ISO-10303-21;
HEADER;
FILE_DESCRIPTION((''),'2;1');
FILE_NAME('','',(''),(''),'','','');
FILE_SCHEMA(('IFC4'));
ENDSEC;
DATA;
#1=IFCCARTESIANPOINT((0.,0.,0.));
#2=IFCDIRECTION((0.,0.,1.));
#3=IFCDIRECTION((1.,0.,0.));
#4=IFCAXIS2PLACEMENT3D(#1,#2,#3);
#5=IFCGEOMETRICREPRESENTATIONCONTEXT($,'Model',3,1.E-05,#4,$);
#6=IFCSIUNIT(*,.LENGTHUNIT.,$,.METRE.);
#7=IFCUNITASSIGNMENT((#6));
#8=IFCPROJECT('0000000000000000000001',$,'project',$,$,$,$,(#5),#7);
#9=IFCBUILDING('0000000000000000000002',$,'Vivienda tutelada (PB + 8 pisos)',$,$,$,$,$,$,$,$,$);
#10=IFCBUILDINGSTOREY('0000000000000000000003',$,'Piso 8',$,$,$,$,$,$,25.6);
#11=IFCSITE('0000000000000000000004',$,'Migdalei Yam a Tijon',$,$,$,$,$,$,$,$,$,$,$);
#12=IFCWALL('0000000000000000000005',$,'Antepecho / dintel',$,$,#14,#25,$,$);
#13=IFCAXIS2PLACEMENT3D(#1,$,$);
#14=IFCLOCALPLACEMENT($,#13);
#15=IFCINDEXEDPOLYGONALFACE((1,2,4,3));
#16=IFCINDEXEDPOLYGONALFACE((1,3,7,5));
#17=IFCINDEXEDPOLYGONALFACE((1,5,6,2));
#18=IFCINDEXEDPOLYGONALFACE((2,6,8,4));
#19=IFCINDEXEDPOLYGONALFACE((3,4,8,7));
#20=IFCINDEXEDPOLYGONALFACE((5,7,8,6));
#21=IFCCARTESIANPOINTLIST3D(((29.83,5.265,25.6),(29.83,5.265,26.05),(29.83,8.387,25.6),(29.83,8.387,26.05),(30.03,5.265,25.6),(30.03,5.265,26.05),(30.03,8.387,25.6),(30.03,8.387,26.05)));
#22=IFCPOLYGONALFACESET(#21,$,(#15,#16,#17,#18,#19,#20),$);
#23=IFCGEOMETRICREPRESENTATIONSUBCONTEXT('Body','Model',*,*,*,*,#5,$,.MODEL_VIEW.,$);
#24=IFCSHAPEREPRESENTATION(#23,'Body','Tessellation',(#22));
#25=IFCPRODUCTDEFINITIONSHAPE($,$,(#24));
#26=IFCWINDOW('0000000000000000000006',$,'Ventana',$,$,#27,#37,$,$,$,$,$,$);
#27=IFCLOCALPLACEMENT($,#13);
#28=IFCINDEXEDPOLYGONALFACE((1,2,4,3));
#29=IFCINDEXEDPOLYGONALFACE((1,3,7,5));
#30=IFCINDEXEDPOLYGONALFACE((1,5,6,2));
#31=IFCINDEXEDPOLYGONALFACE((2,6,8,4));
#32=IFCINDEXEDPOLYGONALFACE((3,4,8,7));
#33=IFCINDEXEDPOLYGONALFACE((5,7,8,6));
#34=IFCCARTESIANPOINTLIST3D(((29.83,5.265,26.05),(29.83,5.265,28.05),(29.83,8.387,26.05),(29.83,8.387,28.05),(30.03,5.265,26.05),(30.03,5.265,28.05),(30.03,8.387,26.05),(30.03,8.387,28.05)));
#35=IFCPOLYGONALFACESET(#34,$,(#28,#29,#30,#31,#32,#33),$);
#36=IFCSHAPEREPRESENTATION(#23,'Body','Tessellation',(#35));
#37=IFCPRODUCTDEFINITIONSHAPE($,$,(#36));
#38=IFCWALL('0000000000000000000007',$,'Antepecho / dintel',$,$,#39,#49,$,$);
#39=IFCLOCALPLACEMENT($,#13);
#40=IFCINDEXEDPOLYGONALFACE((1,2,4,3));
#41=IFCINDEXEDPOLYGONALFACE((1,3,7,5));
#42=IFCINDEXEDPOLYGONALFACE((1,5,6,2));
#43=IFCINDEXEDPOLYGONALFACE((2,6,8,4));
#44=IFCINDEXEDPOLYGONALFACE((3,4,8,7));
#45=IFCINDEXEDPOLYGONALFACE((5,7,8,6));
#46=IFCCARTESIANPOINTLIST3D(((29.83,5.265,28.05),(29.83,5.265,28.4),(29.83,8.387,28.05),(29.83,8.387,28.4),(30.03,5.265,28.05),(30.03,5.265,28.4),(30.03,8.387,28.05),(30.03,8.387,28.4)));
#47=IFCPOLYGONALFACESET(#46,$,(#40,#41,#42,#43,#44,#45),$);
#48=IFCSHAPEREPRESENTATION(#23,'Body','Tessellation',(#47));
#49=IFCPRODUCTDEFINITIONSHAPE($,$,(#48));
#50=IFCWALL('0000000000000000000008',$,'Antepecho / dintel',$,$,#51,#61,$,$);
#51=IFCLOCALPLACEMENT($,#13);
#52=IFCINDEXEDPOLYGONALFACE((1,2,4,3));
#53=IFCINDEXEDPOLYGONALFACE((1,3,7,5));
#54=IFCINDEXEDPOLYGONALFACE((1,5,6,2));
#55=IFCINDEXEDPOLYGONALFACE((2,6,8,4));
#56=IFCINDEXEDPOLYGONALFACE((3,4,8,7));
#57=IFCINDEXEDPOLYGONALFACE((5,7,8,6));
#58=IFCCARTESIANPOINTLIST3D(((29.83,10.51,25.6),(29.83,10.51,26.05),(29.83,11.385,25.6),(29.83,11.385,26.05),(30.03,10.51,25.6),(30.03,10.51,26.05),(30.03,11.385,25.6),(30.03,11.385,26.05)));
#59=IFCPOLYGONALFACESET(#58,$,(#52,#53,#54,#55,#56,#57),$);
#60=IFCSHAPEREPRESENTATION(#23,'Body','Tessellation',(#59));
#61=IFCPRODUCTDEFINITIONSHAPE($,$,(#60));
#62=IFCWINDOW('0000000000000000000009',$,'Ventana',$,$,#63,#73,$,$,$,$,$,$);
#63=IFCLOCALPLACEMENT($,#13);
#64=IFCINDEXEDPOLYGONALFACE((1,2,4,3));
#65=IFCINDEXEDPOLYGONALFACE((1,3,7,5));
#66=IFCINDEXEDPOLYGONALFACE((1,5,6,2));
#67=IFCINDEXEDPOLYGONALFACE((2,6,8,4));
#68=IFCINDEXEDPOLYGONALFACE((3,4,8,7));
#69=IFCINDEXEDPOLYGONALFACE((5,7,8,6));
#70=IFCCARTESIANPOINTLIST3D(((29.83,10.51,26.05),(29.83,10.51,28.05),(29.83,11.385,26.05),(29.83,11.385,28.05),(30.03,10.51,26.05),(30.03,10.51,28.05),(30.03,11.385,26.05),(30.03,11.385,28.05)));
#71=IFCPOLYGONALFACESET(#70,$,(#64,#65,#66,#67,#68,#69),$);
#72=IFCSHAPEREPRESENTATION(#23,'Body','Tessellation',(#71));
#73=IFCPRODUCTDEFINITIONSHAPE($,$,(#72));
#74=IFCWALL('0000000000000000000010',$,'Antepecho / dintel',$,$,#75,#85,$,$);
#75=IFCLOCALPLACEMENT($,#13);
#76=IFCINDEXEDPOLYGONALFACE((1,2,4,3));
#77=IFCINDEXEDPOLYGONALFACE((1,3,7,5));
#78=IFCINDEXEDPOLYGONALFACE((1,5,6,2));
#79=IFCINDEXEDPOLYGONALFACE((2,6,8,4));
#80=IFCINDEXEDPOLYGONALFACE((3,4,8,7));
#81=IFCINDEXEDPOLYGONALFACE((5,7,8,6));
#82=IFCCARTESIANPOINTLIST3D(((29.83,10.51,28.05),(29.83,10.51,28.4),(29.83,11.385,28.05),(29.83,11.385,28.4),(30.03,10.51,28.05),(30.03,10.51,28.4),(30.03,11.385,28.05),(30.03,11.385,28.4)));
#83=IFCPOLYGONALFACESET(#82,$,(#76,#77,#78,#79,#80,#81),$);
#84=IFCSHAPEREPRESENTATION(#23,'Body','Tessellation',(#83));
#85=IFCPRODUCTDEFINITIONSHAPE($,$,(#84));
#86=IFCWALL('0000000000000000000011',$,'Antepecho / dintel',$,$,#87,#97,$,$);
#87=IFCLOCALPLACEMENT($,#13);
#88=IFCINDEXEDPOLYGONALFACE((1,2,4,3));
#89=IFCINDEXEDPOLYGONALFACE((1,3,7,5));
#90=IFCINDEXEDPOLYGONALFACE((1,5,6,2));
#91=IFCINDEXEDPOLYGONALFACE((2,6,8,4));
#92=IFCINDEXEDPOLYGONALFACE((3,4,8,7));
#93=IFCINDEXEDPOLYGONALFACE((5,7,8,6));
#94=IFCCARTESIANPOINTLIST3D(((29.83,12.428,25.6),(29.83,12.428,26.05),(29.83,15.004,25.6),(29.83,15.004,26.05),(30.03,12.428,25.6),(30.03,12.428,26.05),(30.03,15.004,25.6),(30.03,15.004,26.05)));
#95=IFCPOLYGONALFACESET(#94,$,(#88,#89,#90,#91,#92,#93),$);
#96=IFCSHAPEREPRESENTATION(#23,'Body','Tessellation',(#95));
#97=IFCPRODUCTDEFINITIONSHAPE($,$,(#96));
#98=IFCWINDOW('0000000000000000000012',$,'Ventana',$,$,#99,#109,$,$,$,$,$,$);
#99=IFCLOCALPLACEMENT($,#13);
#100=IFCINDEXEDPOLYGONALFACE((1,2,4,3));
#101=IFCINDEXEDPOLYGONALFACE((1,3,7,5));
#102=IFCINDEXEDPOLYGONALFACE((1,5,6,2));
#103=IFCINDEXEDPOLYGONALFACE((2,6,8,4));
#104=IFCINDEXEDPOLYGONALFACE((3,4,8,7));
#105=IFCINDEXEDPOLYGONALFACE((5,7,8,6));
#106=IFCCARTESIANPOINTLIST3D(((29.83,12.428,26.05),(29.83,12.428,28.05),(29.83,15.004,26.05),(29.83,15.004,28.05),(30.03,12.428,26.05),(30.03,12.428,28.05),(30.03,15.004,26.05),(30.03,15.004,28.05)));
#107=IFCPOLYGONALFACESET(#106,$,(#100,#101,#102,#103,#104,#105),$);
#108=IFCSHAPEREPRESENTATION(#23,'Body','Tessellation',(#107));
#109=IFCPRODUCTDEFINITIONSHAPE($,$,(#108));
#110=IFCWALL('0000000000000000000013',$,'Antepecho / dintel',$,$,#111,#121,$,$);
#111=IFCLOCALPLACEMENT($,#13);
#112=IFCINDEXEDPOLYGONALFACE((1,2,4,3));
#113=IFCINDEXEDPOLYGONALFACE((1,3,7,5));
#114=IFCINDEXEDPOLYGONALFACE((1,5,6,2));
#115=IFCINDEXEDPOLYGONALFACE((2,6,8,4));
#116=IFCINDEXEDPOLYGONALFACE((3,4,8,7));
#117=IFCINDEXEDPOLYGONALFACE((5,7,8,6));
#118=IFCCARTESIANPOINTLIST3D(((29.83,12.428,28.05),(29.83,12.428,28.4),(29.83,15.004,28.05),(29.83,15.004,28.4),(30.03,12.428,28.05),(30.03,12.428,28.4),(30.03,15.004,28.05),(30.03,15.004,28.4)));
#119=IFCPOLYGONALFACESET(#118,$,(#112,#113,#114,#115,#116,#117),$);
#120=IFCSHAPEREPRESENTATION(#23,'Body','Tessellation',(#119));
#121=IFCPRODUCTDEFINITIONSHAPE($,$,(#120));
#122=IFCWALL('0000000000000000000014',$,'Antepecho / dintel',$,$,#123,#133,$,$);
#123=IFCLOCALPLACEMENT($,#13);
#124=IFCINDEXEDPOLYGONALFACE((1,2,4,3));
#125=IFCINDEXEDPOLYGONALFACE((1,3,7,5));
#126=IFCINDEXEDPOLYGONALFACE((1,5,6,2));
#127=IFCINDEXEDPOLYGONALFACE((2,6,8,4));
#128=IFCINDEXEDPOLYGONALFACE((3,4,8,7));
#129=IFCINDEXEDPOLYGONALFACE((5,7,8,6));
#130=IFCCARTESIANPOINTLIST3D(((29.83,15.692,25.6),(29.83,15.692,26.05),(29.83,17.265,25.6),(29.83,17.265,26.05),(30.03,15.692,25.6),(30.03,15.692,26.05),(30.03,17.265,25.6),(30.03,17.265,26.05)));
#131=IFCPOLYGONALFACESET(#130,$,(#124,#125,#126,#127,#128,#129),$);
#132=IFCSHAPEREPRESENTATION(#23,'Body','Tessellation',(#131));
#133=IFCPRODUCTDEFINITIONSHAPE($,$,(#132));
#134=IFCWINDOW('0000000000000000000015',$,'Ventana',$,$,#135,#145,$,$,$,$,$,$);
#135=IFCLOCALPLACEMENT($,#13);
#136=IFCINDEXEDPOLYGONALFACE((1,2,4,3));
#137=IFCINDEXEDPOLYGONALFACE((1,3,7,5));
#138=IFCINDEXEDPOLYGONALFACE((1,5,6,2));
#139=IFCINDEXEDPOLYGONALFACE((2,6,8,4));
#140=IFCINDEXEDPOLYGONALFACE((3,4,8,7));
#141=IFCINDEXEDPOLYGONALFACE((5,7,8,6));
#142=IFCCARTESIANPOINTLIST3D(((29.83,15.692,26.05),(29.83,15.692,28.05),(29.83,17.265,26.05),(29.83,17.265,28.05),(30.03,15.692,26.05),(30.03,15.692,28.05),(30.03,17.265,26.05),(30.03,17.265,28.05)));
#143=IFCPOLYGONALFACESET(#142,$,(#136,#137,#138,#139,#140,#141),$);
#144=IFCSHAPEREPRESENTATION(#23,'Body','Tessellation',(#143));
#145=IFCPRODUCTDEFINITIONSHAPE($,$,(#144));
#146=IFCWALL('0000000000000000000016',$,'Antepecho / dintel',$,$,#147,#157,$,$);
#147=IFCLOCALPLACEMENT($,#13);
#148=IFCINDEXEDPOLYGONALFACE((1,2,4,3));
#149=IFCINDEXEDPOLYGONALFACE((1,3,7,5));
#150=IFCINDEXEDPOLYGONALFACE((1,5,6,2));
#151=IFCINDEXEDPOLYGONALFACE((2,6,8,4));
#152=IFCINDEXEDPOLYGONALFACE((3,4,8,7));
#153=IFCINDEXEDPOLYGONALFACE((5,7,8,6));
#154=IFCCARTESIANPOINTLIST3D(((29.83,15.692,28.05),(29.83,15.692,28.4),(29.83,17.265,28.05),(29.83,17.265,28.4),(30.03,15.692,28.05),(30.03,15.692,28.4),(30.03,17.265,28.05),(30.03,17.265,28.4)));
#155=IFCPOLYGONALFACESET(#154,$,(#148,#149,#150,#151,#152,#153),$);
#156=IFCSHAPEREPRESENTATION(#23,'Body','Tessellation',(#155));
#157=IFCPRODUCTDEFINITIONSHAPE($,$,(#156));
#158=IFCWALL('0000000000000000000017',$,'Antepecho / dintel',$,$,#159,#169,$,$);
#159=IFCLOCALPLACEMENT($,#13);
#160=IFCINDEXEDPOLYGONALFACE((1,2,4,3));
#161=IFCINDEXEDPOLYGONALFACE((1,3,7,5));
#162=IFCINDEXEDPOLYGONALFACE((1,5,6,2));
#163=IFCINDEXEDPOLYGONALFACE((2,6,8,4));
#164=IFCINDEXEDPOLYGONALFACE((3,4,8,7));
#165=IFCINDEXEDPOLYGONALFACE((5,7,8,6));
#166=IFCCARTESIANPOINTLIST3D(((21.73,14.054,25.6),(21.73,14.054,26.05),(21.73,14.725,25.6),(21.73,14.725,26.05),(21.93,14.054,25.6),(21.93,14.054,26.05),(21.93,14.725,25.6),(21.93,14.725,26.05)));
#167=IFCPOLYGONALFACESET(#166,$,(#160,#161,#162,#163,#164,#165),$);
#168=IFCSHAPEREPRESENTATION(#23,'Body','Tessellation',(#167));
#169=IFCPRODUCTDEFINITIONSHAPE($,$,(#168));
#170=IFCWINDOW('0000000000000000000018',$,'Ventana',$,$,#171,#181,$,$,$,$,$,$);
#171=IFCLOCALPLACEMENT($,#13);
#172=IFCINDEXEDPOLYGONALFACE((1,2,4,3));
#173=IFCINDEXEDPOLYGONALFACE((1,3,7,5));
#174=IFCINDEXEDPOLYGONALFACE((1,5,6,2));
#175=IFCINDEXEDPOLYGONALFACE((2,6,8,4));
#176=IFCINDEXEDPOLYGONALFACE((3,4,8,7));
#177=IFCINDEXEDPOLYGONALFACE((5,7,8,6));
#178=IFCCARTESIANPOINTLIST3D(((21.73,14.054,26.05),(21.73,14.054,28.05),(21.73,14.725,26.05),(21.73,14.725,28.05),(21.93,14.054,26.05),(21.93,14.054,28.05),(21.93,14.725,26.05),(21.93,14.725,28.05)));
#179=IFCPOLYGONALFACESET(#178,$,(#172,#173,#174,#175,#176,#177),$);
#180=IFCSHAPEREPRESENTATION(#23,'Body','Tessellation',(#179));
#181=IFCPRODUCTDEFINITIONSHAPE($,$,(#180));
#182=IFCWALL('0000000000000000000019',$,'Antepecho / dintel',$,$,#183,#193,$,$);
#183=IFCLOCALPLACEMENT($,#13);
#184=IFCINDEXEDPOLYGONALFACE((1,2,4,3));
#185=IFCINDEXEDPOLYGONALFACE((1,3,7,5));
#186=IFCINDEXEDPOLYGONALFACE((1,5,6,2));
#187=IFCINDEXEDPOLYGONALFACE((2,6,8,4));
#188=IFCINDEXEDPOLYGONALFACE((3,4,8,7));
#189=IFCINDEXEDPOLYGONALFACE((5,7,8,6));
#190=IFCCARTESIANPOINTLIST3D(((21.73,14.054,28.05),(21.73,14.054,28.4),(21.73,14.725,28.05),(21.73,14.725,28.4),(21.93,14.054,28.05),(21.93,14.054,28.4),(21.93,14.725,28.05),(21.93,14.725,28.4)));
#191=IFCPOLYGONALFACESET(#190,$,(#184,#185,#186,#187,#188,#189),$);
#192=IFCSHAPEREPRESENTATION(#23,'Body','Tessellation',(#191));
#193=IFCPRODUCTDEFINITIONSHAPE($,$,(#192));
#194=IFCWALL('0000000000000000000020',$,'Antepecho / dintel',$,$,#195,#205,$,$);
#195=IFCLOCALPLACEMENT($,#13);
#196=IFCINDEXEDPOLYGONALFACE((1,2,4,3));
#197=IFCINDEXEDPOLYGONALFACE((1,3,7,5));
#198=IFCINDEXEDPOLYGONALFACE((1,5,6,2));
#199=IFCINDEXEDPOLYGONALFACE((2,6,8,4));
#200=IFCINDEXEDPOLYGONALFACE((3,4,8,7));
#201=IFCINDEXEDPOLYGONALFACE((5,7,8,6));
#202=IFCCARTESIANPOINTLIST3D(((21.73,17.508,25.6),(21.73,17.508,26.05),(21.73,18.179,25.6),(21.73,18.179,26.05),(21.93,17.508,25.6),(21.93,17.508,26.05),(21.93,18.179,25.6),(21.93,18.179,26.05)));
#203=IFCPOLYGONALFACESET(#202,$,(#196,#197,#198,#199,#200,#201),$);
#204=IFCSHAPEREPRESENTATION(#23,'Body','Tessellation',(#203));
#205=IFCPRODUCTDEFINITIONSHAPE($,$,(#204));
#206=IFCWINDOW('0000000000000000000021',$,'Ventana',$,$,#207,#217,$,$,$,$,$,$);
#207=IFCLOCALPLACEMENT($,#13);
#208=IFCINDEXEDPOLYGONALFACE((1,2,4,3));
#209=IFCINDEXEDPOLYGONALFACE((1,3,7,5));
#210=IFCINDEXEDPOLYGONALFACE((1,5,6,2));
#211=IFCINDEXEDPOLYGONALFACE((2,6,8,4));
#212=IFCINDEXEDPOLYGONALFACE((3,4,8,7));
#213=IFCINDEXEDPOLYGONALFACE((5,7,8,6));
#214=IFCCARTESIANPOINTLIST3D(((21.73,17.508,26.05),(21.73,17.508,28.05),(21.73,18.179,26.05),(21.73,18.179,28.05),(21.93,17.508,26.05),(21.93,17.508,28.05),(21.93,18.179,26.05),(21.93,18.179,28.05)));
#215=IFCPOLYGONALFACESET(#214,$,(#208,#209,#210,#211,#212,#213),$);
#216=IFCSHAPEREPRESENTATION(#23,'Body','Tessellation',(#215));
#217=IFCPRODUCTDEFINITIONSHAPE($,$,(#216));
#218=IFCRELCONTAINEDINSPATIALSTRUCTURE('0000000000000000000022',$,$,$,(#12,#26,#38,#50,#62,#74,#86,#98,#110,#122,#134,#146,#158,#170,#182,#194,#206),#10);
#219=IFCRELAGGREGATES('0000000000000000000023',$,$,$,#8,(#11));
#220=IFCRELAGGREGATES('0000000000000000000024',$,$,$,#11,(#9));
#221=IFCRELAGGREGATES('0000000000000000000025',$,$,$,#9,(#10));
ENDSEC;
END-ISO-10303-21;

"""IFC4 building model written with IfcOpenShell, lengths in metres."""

from ifc_helpers import new_model, si_unit, frame, origin_with_axes, context, subcontext, project, spatial, line, indexed_curve, outline, extrude, element, save


model = new_model("IFC4")

# Units and contexts
model_context = context("Model", 3, precision=1e-05, world=origin_with_axes())
body_context = subcontext(model_context, "Body", "Model", "MODEL_VIEW")
ifc_project = project(units=[si_unit("LENGTHUNIT", "METRE")], contexts=[model_context])

# Site, building, storey
site = spatial("IfcSite", under=ifc_project, Name="Migdalei Yam a Tijon")
building = spatial("IfcBuilding", under=site, Name="Vivienda tutelada (PB + 8 pisos)")
storey = spatial("IfcBuildingStorey", under=building, Name="Piso 8", Elevation=25.6)

# Wall
element("IfcWall", 1, inside=storey, Name="Antepecho / dintel", context=body_context, shape_type="SweptSolid", body=[
    extrude(outline(indexed_curve([(0.0, 0.0), (0.2, 0.0), (0.2, 3.122), (0.0, 3.122)], segments=[line(1, 2, 3, 4, 1)])), frame((29.83, 5.265, 25.6), z_axis=(0.0, 0.0, 1.0), x_axis=(1.0, 0.0, 0.0)), (0.0, 0.0, 1.0), 0.45),
])

# Window
element("IfcWindow", 2, inside=storey, Name="Ventana", context=body_context, shape_type="SweptSolid", body=[
    extrude(outline(indexed_curve([(0.0, 0.0), (0.2, 0.0), (0.2, 3.122), (0.0, 3.122)], segments=[line(1, 2, 3, 4, 1)])), frame((29.83, 5.265, 26.05), z_axis=(0.0, 0.0, 1.0), x_axis=(1.0, 0.0, 0.0)), (0.0, 0.0, 1.0), 2.0),
])

# Walls
element("IfcWall", 3, inside=storey, Name="Antepecho / dintel", context=body_context, shape_type="SweptSolid", body=[
    extrude(outline(indexed_curve([(0.0, 0.0), (0.2, 0.0), (0.2, 3.122), (0.0, 3.122)], segments=[line(1, 2, 3, 4, 1)])), frame((29.83, 5.265, 28.05), z_axis=(0.0, 0.0, 1.0), x_axis=(1.0, 0.0, 0.0)), (0.0, 0.0, 1.0), 0.35),
])
element("IfcWall", 4, inside=storey, Name="Antepecho / dintel", context=body_context, shape_type="SweptSolid", body=[
    extrude(outline(indexed_curve([(0.0, 0.0), (0.2, 0.0), (0.2, 0.875), (0.0, 0.875)], segments=[line(1, 2, 3, 4, 1)])), frame((29.83, 10.51, 25.6), z_axis=(0.0, 0.0, 1.0), x_axis=(1.0, 0.0, 0.0)), (0.0, 0.0, 1.0), 0.45),
])

# Window
element("IfcWindow", 5, inside=storey, Name="Ventana", context=body_context, shape_type="SweptSolid", body=[
    extrude(outline(indexed_curve([(0.0, 0.0), (0.2, 0.0), (0.2, 0.875), (0.0, 0.875)], segments=[line(1, 2, 3, 4, 1)])), frame((29.83, 10.51, 26.05), z_axis=(0.0, 0.0, 1.0), x_axis=(1.0, 0.0, 0.0)), (0.0, 0.0, 1.0), 2.0),
])

# Walls
element("IfcWall", 6, inside=storey, Name="Antepecho / dintel", context=body_context, shape_type="SweptSolid", body=[
    extrude(outline(indexed_curve([(0.0, 0.0), (0.2, 0.0), (0.2, 0.875), (0.0, 0.875)], segments=[line(1, 2, 3, 4, 1)])), frame((29.83, 10.51, 28.05), z_axis=(0.0, 0.0, 1.0), x_axis=(1.0, 0.0, 0.0)), (0.0, 0.0, 1.0), 0.35),
])
element("IfcWall", 7, inside=storey, Name="Antepecho / dintel", context=body_context, shape_type="SweptSolid", body=[
    extrude(outline(indexed_curve([(0.0, 0.0), (0.2, 0.0), (0.2, 2.576), (0.0, 2.576)], segments=[line(1, 2, 3, 4, 1)])), frame((29.83, 12.428, 25.6), z_axis=(0.0, 0.0, 1.0), x_axis=(1.0, 0.0, 0.0)), (0.0, 0.0, 1.0), 0.45),
])

# Window
element("IfcWindow", 8, inside=storey, Name="Ventana", context=body_context, shape_type="SweptSolid", body=[
    extrude(outline(indexed_curve([(0.0, 0.0), (0.2, 0.0), (0.2, 2.576), (0.0, 2.576)], segments=[line(1, 2, 3, 4, 1)])), frame((29.83, 12.428, 26.05), z_axis=(0.0, 0.0, 1.0), x_axis=(1.0, 0.0, 0.0)), (0.0, 0.0, 1.0), 2.0),
])

# Walls
element("IfcWall", 9, inside=storey, Name="Antepecho / dintel", context=body_context, shape_type="SweptSolid", body=[
    extrude(outline(indexed_curve([(0.0, 0.0), (0.2, 0.0), (0.2, 2.576), (0.0, 2.576)], segments=[line(1, 2, 3, 4, 1)])), frame((29.83, 12.428, 28.05), z_axis=(0.0, 0.0, 1.0), x_axis=(1.0, 0.0, 0.0)), (0.0, 0.0, 1.0), 0.35),
])
element("IfcWall", 10, inside=storey, Name="Antepecho / dintel", context=body_context, shape_type="SweptSolid", body=[
    extrude(outline(indexed_curve([(0.0, 0.0), (0.2, 0.0), (0.2, 1.573), (0.0, 1.573)], segments=[line(1, 2, 3, 4, 1)])), frame((29.83, 15.692, 25.6), z_axis=(0.0, 0.0, 1.0), x_axis=(1.0, 0.0, 0.0)), (0.0, 0.0, 1.0), 0.45),
])

# Window
element("IfcWindow", 11, inside=storey, Name="Ventana", context=body_context, shape_type="SweptSolid", body=[
    extrude(outline(indexed_curve([(0.0, 0.0), (0.2, 0.0), (0.2, 1.573), (0.0, 1.573)], segments=[line(1, 2, 3, 4, 1)])), frame((29.83, 15.692, 26.05), z_axis=(0.0, 0.0, 1.0), x_axis=(1.0, 0.0, 0.0)), (0.0, 0.0, 1.0), 2.0),
])

# Walls
element("IfcWall", 12, inside=storey, Name="Antepecho / dintel", context=body_context, shape_type="SweptSolid", body=[
    extrude(outline(indexed_curve([(0.0, 0.0), (0.2, 0.0), (0.2, 1.573), (0.0, 1.573)], segments=[line(1, 2, 3, 4, 1)])), frame((29.83, 15.692, 28.05), z_axis=(0.0, 0.0, 1.0), x_axis=(1.0, 0.0, 0.0)), (0.0, 0.0, 1.0), 0.35),
])
element("IfcWall", 13, inside=storey, Name="Antepecho / dintel", context=body_context, shape_type="SweptSolid", body=[
    extrude(outline(indexed_curve([(0.0, 0.0), (0.2, 0.0), (0.2, 0.671), (0.0, 0.671)], segments=[line(1, 2, 3, 4, 1)])), frame((21.73, 14.054, 25.6), z_axis=(0.0, 0.0, 1.0), x_axis=(1.0, 0.0, 0.0)), (0.0, 0.0, 1.0), 0.45),
])

# Window
element("IfcWindow", 14, inside=storey, Name="Ventana", context=body_context, shape_type="SweptSolid", body=[
    extrude(outline(indexed_curve([(0.0, 0.0), (0.2, 0.0), (0.2, 0.671), (0.0, 0.671)], segments=[line(1, 2, 3, 4, 1)])), frame((21.73, 14.054, 26.05), z_axis=(0.0, 0.0, 1.0), x_axis=(1.0, 0.0, 0.0)), (0.0, 0.0, 1.0), 2.0),
])

# Walls
element("IfcWall", 15, inside=storey, Name="Antepecho / dintel", context=body_context, shape_type="SweptSolid", body=[
    extrude(outline(indexed_curve([(0.0, 0.0), (0.2, 0.0), (0.2, 0.671), (0.0, 0.671)], segments=[line(1, 2, 3, 4, 1)])), frame((21.73, 14.054, 28.05), z_axis=(0.0, 0.0, 1.0), x_axis=(1.0, 0.0, 0.0)), (0.0, 0.0, 1.0), 0.35),
])
element("IfcWall", 16, inside=storey, Name="Antepecho / dintel", context=body_context, shape_type="SweptSolid", body=[
    extrude(outline(indexed_curve([(0.0, 0.0), (0.2, 0.0), (0.2, 0.671), (0.0, 0.671)], segments=[line(1, 2, 3, 4, 1)])), frame((21.73, 17.508, 25.6), z_axis=(0.0, 0.0, 1.0), x_axis=(1.0, 0.0, 0.0)), (0.0, 0.0, 1.0), 0.45),
])

# Window
element("IfcWindow", 17, inside=storey, Name="Ventana", context=body_context, shape_type="SweptSolid", body=[
    extrude(outline(indexed_curve([(0.0, 0.0), (0.2, 0.0), (0.2, 0.671), (0.0, 0.671)], segments=[line(1, 2, 3, 4, 1)])), frame((21.73, 17.508, 26.05), z_axis=(0.0, 0.0, 1.0), x_axis=(1.0, 0.0, 0.0)), (0.0, 0.0, 1.0), 2.0),
])

save(model, "model.ifc")
